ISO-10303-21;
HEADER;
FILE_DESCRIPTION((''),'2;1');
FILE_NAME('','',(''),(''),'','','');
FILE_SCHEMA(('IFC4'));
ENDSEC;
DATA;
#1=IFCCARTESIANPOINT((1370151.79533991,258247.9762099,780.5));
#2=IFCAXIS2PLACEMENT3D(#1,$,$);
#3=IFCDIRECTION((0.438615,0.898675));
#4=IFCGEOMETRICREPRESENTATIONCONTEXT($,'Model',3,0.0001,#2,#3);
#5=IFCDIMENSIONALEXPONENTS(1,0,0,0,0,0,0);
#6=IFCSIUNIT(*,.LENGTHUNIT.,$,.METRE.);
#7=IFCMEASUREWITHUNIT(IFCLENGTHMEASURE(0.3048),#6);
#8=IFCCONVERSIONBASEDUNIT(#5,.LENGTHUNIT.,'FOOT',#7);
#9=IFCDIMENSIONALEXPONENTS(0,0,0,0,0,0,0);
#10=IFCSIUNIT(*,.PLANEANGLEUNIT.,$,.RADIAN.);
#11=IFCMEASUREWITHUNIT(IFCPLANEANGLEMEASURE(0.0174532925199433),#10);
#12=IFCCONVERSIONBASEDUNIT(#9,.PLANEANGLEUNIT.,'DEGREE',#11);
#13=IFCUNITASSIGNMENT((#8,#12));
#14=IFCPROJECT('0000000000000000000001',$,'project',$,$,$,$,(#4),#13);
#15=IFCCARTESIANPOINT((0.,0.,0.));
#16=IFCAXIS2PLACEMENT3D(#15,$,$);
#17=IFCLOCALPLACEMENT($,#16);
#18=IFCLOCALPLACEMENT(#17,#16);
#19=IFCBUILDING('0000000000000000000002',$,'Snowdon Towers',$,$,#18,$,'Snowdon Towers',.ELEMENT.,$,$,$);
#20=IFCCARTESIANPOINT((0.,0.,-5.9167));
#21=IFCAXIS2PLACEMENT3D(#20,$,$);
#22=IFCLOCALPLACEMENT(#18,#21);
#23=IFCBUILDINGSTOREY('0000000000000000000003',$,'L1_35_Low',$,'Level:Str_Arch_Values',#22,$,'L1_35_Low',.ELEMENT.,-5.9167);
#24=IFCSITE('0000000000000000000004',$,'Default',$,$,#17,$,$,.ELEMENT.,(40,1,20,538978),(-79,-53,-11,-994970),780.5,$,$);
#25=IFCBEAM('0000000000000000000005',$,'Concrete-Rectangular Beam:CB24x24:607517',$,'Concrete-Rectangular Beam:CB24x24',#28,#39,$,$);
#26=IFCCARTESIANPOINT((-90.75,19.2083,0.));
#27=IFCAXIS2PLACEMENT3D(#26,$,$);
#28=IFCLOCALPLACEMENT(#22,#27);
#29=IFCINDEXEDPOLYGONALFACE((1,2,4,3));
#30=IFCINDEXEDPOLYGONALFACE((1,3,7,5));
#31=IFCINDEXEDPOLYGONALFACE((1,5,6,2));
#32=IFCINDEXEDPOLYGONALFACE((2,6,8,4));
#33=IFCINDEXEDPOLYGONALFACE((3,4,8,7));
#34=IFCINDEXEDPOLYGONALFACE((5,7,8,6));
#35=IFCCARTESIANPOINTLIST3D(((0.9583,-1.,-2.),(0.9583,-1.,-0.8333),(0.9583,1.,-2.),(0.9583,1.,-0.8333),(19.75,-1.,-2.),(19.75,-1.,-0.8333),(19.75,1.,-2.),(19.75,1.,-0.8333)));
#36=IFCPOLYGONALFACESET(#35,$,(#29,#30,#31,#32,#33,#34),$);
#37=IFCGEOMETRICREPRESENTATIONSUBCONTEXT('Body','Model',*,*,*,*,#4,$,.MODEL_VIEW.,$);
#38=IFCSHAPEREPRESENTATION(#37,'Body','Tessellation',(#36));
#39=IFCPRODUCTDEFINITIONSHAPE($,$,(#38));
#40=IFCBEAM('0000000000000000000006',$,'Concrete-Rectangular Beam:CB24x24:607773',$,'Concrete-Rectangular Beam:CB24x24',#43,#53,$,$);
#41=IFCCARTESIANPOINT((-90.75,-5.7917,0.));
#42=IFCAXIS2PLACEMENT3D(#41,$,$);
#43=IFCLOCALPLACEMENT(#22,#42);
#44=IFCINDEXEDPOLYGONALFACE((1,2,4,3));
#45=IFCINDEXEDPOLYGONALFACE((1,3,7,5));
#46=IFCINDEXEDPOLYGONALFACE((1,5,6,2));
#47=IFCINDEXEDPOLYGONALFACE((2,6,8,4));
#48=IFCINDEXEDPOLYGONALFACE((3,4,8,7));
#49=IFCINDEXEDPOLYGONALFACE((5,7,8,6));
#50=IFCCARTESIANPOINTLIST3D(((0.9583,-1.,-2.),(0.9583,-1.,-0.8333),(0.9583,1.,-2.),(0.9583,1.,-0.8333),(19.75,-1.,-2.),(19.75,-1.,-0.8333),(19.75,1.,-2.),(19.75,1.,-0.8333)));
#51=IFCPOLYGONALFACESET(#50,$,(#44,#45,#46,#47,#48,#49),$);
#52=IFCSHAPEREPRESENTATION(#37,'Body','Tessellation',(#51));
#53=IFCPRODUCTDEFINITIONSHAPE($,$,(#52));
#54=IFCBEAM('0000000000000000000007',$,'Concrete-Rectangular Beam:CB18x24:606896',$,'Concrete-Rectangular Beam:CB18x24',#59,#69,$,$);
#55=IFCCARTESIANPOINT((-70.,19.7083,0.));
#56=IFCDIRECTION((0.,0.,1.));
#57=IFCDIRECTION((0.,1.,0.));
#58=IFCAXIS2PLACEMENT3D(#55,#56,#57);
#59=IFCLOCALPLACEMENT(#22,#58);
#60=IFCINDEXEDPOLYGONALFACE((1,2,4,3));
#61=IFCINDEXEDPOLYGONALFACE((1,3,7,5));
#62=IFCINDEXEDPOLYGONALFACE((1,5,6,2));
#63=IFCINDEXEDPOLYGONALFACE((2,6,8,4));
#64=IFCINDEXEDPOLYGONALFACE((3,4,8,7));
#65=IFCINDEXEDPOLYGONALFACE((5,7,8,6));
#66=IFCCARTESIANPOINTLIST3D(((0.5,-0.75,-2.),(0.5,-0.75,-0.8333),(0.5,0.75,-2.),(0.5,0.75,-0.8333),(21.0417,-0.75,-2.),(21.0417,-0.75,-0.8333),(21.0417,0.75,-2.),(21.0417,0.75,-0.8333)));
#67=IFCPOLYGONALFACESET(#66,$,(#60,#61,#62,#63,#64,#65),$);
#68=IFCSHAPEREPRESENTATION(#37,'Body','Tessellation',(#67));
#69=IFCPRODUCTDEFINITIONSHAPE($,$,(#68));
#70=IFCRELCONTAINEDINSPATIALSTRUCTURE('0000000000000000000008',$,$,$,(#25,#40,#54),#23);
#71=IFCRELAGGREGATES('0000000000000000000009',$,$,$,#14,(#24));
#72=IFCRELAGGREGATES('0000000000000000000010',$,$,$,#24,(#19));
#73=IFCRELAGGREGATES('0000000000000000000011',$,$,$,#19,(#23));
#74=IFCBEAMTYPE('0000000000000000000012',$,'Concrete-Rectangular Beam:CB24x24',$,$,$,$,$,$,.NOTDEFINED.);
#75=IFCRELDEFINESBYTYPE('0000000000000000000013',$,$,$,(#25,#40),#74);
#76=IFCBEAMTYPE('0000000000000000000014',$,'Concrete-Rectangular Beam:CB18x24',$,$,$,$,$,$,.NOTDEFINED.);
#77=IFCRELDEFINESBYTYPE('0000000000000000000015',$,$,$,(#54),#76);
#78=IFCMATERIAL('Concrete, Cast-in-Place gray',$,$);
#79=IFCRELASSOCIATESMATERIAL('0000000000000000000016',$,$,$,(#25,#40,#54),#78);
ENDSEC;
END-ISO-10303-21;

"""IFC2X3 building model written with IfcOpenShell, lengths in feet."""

from ifc_helpers import new_model, entity, si_unit, converted_unit, direction, frame, frame_2d, origin, place, context, subcontext, project, spatial, rectangle, extrude, material, type_object, element, save


model = new_model("IFC2X3")

# Units and contexts
model_context = context("Model", 3, precision=0.0001, world=frame((1370151.79533991, 258247.9762099, 780.5)), true_north=direction((0.438615, 0.898675)))
body_context = subcontext(model_context, "Body", "Model", "MODEL_VIEW")
ifc_project = project(units=[converted_unit("LENGTHUNIT", "FOOT", entity("IfcLengthMeasure", 0.3048), si_unit("LENGTHUNIT", "METRE"), dimensions=[1, 0, 0, 0, 0, 0, 0]), converted_unit("PLANEANGLEUNIT", "DEGREE", entity("IfcPlaneAngleMeasure", 0.0174532925199433), si_unit("PLANEANGLEUNIT", "RADIAN"), dimensions=[0, 0, 0, 0, 0, 0, 0])], contexts=[model_context])

# Site, building, storey
site_placement = place(None, origin())
site = spatial("IfcSite", under=ifc_project, at=site_placement, Name="Default", CompositionType="ELEMENT", RefLatitude=(40, 1, 20, 538978), RefLongitude=(-79, -53, -11, -994970), RefElevation=780.5)
building_placement = place(site_placement, origin())
building = spatial("IfcBuilding", under=site, at=building_placement, Name="Snowdon Towers", LongName="Snowdon Towers", CompositionType="ELEMENT")
storey_placement = place(building_placement, frame((0.0, 0.0, -5.9167)))
storey = spatial("IfcBuildingStorey", under=building, at=storey_placement, Name="L1_35_Low", ObjectType="Level:Str_Arch_Values", LongName="L1_35_Low", CompositionType="ELEMENT", Elevation=-5.9167)

# Beams
ifc_material_1 = material(Name="Concrete, Cast-in-Place gray")
beam_type_1 = type_object("IfcBeamType", Name="Concrete-Rectangular Beam:CB24x24", PredefinedType="NOTDEFINED")
beam_1_placement = place(storey_placement, frame((-90.75, 19.2083, 0.0)))
element("IfcBeam", 1, at=beam_1_placement, inside=storey, type_object=beam_type_1, material=ifc_material_1, Name="Concrete-Rectangular Beam:CB24x24:607517", ObjectType="Concrete-Rectangular Beam:CB24x24", context=body_context, shape_type="SweptSolid", body=[
    extrude(rectangle(XDim=1.1667, YDim=2.0, at=frame_2d((0.0, 0.0), x_axis=(1.0, 0.0))), frame((0.9583, 0.0, -1.4167), z_axis=(1.0, 0.0, 0.0), x_axis=(0.0, 0.0, -1.0)), (0.0, 0.0, 1.0), 18.7917),
])
beam_2_placement = place(storey_placement, frame((-90.75, -5.7917, 0.0)))
element("IfcBeam", 2, at=beam_2_placement, inside=storey, type_object=beam_type_1, material=ifc_material_1, Name="Concrete-Rectangular Beam:CB24x24:607773", ObjectType="Concrete-Rectangular Beam:CB24x24", context=body_context, shape_type="SweptSolid", body=[
    extrude(rectangle(XDim=1.1667, YDim=2.0, at=frame_2d((0.0, 0.0), x_axis=(1.0, 0.0))), frame((0.9583, 0.0, -1.4167), z_axis=(1.0, 0.0, 0.0), x_axis=(0.0, 0.0, -1.0)), (0.0, 0.0, 1.0), 18.7917),
])
beam_type_2 = type_object("IfcBeamType", Name="Concrete-Rectangular Beam:CB18x24", PredefinedType="NOTDEFINED")
beam_3_placement = place(storey_placement, frame((-70.0, 19.7083, 0.0), z_axis=(0.0, 0.0, 1.0), x_axis=(0.0, 1.0, 0.0)))
element("IfcBeam", 3, at=beam_3_placement, inside=storey, type_object=beam_type_2, material=ifc_material_1, Name="Concrete-Rectangular Beam:CB18x24:606896", ObjectType="Concrete-Rectangular Beam:CB18x24", context=body_context, shape_type="SweptSolid", body=[
    extrude(rectangle(XDim=1.1667, YDim=1.5, at=frame_2d((0.0, 0.0), x_axis=(1.0, 0.0))), frame((0.5, 0.0, -1.4167), z_axis=(1.0, 0.0, 0.0), x_axis=(0.0, 0.0, -1.0)), (0.0, 0.0, 1.0), 20.5417),
])

save(model, "model.ifc")
